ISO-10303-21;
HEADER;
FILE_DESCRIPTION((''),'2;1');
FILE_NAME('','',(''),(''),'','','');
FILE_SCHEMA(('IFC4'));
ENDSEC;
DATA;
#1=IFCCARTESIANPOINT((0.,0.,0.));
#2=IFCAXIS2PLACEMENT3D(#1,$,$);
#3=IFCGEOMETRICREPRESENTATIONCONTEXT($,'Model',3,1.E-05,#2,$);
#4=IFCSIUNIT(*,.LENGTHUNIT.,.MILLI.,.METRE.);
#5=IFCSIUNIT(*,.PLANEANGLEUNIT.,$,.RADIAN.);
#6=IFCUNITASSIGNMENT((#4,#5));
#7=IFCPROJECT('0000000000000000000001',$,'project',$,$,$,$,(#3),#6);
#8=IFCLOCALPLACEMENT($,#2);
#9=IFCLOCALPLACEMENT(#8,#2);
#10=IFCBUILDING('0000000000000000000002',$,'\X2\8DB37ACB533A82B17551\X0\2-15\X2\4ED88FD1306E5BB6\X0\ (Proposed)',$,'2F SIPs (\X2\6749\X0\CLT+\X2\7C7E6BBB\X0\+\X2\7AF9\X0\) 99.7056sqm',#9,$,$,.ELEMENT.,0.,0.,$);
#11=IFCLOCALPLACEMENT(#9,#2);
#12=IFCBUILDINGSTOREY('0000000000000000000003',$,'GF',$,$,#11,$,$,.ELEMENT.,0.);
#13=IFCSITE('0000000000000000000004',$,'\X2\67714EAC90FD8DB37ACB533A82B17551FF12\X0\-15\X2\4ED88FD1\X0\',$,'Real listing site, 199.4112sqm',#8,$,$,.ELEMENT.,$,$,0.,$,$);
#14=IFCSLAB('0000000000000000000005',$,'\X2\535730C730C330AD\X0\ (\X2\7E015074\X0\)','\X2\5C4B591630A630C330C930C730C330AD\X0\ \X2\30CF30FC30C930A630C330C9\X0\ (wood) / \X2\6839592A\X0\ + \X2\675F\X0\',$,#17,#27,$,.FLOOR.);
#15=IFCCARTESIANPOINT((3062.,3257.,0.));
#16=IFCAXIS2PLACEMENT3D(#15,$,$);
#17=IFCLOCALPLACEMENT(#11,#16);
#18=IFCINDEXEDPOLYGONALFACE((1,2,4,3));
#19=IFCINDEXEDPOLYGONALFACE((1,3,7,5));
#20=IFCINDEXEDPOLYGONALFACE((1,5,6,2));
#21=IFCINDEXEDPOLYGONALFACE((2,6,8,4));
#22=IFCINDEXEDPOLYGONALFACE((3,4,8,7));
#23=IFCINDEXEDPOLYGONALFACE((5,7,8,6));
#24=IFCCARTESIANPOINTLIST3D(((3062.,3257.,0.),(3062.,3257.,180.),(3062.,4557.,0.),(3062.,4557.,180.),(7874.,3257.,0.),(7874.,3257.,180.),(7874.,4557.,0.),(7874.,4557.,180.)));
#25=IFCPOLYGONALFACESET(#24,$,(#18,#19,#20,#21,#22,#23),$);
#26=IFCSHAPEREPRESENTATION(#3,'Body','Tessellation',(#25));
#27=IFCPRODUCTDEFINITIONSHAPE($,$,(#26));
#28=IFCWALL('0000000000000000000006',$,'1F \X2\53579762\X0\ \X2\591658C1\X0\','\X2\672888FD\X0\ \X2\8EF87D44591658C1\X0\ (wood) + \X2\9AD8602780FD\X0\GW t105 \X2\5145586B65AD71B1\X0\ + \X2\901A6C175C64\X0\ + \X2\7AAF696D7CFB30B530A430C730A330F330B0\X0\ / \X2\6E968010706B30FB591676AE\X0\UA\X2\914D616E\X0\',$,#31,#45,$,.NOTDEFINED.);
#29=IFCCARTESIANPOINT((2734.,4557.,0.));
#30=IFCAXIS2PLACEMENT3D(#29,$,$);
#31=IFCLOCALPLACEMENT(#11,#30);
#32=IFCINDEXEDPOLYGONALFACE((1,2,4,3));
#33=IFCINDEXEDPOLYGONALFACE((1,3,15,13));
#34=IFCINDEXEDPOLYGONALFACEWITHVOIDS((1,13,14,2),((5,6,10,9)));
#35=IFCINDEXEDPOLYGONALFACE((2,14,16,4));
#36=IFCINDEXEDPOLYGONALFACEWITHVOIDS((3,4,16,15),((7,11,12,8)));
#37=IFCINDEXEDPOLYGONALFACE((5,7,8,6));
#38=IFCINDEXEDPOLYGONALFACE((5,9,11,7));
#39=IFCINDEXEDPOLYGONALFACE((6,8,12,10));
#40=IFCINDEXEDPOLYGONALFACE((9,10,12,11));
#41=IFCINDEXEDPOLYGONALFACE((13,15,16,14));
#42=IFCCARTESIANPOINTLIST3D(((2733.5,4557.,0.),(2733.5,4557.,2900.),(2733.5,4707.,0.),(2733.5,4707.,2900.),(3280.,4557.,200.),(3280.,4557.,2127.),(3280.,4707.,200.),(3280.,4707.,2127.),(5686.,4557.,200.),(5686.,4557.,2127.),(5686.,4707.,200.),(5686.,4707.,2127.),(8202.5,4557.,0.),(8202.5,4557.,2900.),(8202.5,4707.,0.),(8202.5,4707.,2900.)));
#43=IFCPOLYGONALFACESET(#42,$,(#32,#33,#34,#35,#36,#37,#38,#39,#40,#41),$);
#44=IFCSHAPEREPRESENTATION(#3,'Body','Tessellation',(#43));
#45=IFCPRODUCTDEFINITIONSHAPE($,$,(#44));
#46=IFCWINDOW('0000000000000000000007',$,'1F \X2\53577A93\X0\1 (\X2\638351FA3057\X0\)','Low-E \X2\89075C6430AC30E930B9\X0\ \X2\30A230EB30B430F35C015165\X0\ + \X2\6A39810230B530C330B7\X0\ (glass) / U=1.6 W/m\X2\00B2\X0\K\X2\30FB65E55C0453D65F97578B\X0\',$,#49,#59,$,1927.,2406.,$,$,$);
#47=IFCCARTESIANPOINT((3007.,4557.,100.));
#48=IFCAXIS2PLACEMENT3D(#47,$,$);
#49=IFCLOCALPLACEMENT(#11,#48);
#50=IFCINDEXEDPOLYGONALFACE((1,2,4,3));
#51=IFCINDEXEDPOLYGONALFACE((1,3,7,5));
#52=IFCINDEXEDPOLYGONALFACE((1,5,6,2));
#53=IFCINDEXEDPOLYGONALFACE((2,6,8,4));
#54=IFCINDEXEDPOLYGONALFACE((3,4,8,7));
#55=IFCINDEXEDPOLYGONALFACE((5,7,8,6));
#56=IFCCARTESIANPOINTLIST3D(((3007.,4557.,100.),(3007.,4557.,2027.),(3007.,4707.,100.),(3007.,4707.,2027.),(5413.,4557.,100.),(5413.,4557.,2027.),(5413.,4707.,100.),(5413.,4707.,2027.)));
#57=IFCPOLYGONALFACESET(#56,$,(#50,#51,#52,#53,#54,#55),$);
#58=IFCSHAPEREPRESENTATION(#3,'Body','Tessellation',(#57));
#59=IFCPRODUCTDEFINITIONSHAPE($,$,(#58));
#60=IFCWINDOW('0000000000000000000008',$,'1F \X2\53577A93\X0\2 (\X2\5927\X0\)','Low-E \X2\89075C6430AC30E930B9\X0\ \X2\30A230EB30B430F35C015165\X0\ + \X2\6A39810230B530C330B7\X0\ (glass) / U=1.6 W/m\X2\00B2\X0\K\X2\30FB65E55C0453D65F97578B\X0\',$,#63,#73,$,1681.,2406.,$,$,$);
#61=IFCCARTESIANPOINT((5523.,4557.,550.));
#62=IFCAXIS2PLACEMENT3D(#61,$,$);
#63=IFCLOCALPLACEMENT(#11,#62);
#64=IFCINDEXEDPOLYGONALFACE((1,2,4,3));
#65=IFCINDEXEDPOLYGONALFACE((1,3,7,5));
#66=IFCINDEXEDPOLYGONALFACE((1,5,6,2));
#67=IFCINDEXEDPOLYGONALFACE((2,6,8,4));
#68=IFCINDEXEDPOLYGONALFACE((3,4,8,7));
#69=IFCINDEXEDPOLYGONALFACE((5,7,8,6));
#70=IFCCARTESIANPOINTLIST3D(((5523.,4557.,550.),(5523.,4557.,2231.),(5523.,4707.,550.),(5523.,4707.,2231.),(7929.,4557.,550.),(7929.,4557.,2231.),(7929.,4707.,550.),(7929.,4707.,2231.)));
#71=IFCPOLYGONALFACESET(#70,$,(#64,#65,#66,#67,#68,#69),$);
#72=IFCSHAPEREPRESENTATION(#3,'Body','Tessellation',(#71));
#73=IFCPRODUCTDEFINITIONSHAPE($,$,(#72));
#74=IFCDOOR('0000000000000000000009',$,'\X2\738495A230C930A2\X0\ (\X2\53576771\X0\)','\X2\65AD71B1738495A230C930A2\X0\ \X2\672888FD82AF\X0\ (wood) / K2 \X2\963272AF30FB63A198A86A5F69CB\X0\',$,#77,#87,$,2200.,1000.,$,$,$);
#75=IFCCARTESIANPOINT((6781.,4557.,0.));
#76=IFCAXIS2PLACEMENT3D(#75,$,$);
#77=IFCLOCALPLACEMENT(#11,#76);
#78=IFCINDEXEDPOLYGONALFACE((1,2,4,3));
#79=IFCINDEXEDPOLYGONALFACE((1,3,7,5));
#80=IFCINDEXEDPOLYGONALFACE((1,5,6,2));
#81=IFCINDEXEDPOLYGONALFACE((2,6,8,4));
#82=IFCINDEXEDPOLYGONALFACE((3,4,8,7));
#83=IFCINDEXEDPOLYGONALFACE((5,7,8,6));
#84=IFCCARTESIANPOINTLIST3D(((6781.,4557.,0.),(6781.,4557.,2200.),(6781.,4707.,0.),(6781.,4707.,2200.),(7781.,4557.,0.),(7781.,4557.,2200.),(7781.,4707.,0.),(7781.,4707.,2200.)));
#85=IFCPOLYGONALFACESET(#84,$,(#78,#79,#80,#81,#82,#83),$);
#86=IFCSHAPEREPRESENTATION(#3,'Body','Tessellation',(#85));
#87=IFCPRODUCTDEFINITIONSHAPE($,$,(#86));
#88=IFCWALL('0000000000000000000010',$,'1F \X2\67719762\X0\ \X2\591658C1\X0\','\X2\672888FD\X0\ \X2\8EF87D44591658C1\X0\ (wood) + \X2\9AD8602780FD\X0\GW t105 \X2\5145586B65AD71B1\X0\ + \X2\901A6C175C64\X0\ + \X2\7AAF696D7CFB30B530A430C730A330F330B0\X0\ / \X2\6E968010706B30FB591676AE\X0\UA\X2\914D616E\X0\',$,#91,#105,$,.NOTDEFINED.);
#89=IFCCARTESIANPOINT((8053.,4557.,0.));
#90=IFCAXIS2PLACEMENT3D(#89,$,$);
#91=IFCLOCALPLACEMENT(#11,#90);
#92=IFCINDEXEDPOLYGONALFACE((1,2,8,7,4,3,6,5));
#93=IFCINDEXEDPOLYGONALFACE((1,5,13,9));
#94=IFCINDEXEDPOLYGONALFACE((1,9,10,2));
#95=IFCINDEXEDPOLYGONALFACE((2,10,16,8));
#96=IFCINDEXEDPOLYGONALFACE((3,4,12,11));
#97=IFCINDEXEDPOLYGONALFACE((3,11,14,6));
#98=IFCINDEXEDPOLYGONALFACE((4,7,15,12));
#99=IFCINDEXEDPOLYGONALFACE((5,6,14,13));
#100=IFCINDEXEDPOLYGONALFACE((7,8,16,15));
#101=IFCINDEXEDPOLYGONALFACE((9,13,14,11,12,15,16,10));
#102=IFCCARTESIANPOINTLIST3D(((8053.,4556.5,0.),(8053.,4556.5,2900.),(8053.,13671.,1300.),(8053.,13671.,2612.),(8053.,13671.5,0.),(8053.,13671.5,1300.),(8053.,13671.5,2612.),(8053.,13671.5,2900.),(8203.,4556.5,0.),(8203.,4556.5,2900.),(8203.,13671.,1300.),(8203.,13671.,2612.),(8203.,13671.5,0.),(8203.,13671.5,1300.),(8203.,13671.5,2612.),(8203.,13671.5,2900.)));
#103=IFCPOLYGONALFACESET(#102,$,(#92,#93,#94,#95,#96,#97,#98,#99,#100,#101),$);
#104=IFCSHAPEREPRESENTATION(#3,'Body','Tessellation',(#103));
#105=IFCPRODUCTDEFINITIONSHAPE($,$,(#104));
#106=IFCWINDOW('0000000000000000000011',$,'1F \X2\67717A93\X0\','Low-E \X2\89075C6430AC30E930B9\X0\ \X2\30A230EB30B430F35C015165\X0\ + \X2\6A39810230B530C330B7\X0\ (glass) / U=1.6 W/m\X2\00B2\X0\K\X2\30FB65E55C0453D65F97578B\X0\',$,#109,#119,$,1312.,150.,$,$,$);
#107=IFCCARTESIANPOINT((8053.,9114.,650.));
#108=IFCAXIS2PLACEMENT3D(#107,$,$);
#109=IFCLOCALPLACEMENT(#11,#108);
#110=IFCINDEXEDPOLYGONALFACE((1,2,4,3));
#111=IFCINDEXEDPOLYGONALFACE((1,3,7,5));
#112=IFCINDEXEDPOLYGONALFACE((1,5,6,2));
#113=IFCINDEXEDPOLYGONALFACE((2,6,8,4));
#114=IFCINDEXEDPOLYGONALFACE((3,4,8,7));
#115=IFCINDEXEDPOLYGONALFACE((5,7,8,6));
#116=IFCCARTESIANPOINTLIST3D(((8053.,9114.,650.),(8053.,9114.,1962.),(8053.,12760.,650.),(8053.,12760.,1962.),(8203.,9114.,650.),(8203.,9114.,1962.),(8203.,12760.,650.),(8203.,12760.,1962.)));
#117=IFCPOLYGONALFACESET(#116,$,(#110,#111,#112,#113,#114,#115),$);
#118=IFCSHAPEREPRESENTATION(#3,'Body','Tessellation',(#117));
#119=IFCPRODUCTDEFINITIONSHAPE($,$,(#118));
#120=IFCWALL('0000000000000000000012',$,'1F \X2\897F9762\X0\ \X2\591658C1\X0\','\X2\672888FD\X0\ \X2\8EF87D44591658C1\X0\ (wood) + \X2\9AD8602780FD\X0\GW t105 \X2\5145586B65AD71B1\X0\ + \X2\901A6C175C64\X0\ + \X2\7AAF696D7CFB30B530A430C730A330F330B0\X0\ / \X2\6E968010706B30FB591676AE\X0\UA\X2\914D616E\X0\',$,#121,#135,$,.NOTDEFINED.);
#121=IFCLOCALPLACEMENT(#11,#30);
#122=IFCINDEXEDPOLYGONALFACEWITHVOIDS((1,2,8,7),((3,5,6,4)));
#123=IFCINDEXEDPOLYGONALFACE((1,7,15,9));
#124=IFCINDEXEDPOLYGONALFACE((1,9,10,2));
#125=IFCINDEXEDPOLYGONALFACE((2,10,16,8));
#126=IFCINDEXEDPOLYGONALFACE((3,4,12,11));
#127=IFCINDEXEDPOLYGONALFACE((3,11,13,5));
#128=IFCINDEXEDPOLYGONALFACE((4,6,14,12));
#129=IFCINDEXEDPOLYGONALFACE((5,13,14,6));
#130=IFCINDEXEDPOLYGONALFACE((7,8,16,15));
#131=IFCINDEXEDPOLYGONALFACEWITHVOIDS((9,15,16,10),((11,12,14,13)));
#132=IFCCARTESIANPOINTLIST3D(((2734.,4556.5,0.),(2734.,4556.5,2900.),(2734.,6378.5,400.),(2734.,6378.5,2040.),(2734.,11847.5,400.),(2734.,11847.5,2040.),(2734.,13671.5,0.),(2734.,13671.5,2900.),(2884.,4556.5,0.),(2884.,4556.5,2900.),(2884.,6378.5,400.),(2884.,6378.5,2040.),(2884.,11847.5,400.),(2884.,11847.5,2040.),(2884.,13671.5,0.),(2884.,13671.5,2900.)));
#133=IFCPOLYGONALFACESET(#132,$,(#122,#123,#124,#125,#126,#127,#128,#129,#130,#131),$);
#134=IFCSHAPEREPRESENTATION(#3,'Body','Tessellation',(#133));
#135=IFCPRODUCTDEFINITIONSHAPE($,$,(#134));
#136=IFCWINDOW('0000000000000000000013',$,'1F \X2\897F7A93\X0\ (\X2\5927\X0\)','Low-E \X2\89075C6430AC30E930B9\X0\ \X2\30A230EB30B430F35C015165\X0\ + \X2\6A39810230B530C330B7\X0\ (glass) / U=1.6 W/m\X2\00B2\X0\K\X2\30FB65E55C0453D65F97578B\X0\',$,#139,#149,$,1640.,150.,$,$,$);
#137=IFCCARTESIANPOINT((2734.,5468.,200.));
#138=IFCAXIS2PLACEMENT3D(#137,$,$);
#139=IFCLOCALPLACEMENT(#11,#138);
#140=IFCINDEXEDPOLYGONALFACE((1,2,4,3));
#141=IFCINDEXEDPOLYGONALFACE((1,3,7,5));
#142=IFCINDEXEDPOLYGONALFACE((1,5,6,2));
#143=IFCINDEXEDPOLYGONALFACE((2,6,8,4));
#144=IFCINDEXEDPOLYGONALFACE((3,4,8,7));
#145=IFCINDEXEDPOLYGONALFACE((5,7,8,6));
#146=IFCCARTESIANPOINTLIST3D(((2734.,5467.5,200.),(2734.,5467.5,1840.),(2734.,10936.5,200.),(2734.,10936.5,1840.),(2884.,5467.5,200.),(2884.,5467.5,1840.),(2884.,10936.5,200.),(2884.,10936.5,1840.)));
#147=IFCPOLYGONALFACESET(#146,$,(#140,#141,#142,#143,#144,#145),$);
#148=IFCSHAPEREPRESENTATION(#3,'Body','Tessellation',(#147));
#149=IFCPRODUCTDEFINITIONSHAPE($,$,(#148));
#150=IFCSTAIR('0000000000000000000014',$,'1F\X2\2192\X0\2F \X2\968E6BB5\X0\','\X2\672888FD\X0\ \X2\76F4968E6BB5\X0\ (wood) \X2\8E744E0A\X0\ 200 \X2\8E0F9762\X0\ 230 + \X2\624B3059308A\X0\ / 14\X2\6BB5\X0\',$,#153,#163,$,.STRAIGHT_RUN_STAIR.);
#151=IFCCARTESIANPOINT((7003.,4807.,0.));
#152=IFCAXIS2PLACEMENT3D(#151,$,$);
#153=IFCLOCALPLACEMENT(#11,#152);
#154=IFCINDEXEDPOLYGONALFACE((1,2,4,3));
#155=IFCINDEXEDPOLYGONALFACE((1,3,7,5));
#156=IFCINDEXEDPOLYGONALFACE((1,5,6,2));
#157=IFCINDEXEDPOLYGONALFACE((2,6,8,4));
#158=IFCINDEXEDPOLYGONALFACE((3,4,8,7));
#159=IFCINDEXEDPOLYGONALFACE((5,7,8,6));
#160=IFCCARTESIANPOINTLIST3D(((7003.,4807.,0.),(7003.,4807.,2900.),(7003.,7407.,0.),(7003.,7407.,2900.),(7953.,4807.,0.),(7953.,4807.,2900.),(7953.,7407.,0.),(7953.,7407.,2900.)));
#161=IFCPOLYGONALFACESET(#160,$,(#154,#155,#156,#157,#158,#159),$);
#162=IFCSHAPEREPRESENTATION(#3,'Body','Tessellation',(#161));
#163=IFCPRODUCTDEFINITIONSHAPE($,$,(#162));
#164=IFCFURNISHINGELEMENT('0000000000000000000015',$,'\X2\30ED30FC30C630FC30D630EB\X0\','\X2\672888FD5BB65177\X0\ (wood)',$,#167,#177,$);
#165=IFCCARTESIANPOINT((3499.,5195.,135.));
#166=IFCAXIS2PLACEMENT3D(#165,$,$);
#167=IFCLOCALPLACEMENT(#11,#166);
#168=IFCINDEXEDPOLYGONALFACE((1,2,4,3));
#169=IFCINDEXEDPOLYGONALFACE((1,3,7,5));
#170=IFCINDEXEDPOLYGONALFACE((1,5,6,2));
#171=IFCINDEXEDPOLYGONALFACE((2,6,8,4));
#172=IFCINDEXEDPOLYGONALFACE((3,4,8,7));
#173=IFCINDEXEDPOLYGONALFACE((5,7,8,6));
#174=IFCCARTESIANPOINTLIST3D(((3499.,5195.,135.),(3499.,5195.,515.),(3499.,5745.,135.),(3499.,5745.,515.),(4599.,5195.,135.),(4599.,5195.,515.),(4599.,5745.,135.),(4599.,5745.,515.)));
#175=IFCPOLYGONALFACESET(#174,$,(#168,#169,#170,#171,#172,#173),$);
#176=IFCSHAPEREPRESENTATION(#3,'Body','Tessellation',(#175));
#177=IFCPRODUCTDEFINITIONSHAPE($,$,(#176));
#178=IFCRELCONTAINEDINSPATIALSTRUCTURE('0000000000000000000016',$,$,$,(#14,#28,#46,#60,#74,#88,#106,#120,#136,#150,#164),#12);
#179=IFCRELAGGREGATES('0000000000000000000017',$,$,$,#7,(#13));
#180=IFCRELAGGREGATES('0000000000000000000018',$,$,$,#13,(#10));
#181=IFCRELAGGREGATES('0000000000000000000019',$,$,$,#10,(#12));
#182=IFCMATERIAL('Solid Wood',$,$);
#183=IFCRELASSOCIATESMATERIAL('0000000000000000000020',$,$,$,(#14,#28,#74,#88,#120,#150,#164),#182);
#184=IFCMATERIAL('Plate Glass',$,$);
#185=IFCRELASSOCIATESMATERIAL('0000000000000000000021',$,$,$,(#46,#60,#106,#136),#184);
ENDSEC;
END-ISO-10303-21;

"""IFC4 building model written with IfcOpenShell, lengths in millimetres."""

from ifc_helpers import new_model, si_unit, frame, frame_2d, origin, place, context, project, spatial, rectangle, extrude, material, element, fill, save


model = new_model("IFC4")

# Units and contexts
model_context = context("Model", 3, precision=1e-05, world=origin())
ifc_project = project(units=[si_unit("LENGTHUNIT", "METRE", prefix="MILLI"), si_unit("PLANEANGLEUNIT", "RADIAN")], contexts=[model_context])

# Site, building, storey
site_placement = place(None, origin())
site = spatial("IfcSite", under=ifc_project, at=site_placement, Name="東京都足立区花畑２-15付近", ObjectType="Real listing site, 199.4112sqm", CompositionType="ELEMENT", RefElevation=0.0)
building_placement = place(site_placement, origin())
building = spatial("IfcBuilding", under=site, at=building_placement, Name="足立区花畑2-15付近の家 (Proposed)", ObjectType="2F SIPs (杉CLT+籾殻+竹) 99.7056sqm", CompositionType="ELEMENT", ElevationOfRefHeight=0.0, ElevationOfTerrain=0.0)
storey_placement = place(building_placement, origin())
storey = spatial("IfcBuildingStorey", under=building, at=storey_placement, Name="GF", CompositionType="ELEMENT", Elevation=0.0)

# Slab
ifc_material_1 = material(Name="Solid Wood")
slab_1_placement = place(storey_placement, frame((3062.0, 3257.0, 0.0)))
element("IfcSlab", 1, at=slab_1_placement, inside=storey, material=ifc_material_1, Name="南デッキ (縁側)", Description="屋外ウッドデッキ ハードウッド (wood) / 根太 + 束", PredefinedType="FLOOR", context=model_context, shape_type="SweptSolid", body=[
    extrude(rectangle(XDim=4812.0, YDim=1300.0, at=frame_2d((2406.0, 650.0))), frame((3062.0, 3257.0, 0.0)), (0.0, 0.0, 1.0), 180.0),
])

# Wall, openings, windows, door
wall_1_placement = place(storey_placement, frame((2734.0, 4557.0, 0.0)))
wall_1 = element("IfcWall", 2, at=wall_1_placement, inside=storey, material=ifc_material_1, Name="1F 南面 外壁", Description="木製 軸組外壁 (wood) + 高性能GW t105 充填断熱 + 通気層 + 窯業系サイディング / 準耐火・外皮UA配慮", PredefinedType="NOTDEFINED", context=model_context, shape_type="SweptSolid", body=[
    extrude(rectangle(XDim=5469.0, YDim=150.0, at=frame_2d((2734.0, 75.0))), frame((2734.0, 4557.0, 0.0)), (0.0, 0.0, 1.0), 2900.0),
])
opening_1_placement = place(storey_placement, frame((3007.0, 4557.0, 100.0)))
opening_1 = element("IfcOpeningElement", 3, at=opening_1_placement, cuts=wall_1, PredefinedType="NOTDEFINED", context=model_context, shape_type="SweptSolid", body=[
    extrude(rectangle(XDim=2406.0, YDim=150.0, at=frame_2d((1203.0, 75.0))), frame((3007.0, 4557.0, 100.0)), (0.0, 0.0, 1.0), 1927.0),
])
opening_2_placement = place(storey_placement, frame((5523.0, 4557.0, 550.0)))
opening_2 = element("IfcOpeningElement", 4, at=opening_2_placement, cuts=wall_1, PredefinedType="NOTDEFINED", context=model_context, shape_type="SweptSolid", body=[
    extrude(rectangle(XDim=2406.0, YDim=150.0, at=frame_2d((1203.0, 75.0))), frame((5523.0, 4557.0, 550.0)), (0.0, 0.0, 1.0), 1681.0),
])
opening_3_placement = place(storey_placement, frame((6781.0, 4557.0, 0.0)))
opening_3 = element("IfcOpeningElement", 5, at=opening_3_placement, cuts=wall_1, PredefinedType="NOTDEFINED", context=model_context, shape_type="SweptSolid", body=[
    extrude(rectangle(XDim=1000.0, YDim=150.0, at=frame_2d((500.0, 75.0))), frame((6781.0, 4557.0, 0.0)), (0.0, 0.0, 1.0), 2200.0),
])
ifc_material_2 = material(Name="Plate Glass")
window_1_placement = place(storey_placement, frame((3007.0, 4557.0, 100.0)))
window_1 = element("IfcWindow", 6, at=window_1_placement, inside=storey, material=ifc_material_2, Name="1F 南窓1 (掃出し)", Description="Low-E 複層ガラス アルゴン封入 + 樹脂サッシ (glass) / U=1.6 W/m²K・日射取得型", OverallHeight=1927.0, OverallWidth=2406.0, context=model_context, shape_type="SweptSolid", body=[
    extrude(rectangle(XDim=2406.0, YDim=150.0, at=frame_2d((1203.0, 75.0))), frame((3007.0, 4557.0, 100.0)), (0.0, 0.0, 1.0), 1927.0),
])
fill(opening_1, window_1)
window_2_placement = place(storey_placement, frame((5523.0, 4557.0, 550.0)))
window_2 = element("IfcWindow", 7, at=window_2_placement, inside=storey, material=ifc_material_2, Name="1F 南窓2 (大)", Description="Low-E 複層ガラス アルゴン封入 + 樹脂サッシ (glass) / U=1.6 W/m²K・日射取得型", OverallHeight=1681.0, OverallWidth=2406.0, context=model_context, shape_type="SweptSolid", body=[
    extrude(rectangle(XDim=2406.0, YDim=150.0, at=frame_2d((1203.0, 75.0))), frame((5523.0, 4557.0, 550.0)), (0.0, 0.0, 1.0), 1681.0),
])
fill(opening_2, window_2)
door_placement = place(storey_placement, frame((6781.0, 4557.0, 0.0)))
door = element("IfcDoor", 8, at=door_placement, inside=storey, material=ifc_material_1, Name="玄関ドア (南東)", Description="断熱玄関ドア 木製芯 (wood) / K2 防犯・採風機構", OverallHeight=2200.0, OverallWidth=1000.0, context=model_context, shape_type="SweptSolid", body=[
    extrude(rectangle(XDim=1000.0, YDim=150.0, at=frame_2d((500.0, 75.0))), frame((6781.0, 4557.0, 0.0)), (0.0, 0.0, 1.0), 2200.0),
])
fill(opening_3, door)

# Walls, openings, windows
wall_2_placement = place(storey_placement, frame((8053.0, 4557.0, 0.0)))
wall_2 = element("IfcWall", 9, at=wall_2_placement, inside=storey, material=ifc_material_1, Name="1F 東面 外壁", Description="木製 軸組外壁 (wood) + 高性能GW t105 充填断熱 + 通気層 + 窯業系サイディング / 準耐火・外皮UA配慮", PredefinedType="NOTDEFINED", context=model_context, shape_type="SweptSolid", body=[
    extrude(rectangle(XDim=150.0, YDim=9115.0, at=frame_2d((75.0, 4557.0))), frame((8053.0, 4557.0, 0.0)), (0.0, 0.0, 1.0), 2900.0),
])
opening_4_placement = place(storey_placement, frame((8053.0, 9114.0, 650.0)))
opening_4 = element("IfcOpeningElement", 10, at=opening_4_placement, cuts=wall_2, PredefinedType="NOTDEFINED", context=model_context, shape_type="SweptSolid", body=[
    extrude(rectangle(XDim=150.0, YDim=3646.0, at=frame_2d((75.0, 1823.0))), frame((8053.0, 9114.0, 650.0)), (0.0, 0.0, 1.0), 1312.0),
])
window_3_placement = place(storey_placement, frame((8053.0, 9114.0, 650.0)))
window_3 = element("IfcWindow", 11, at=window_3_placement, inside=storey, material=ifc_material_2, Name="1F 東窓", Description="Low-E 複層ガラス アルゴン封入 + 樹脂サッシ (glass) / U=1.6 W/m²K・日射取得型", OverallHeight=1312.0, OverallWidth=150.0, context=model_context, shape_type="SweptSolid", body=[
    extrude(rectangle(XDim=150.0, YDim=3646.0, at=frame_2d((75.0, 1823.0))), frame((8053.0, 9114.0, 650.0)), (0.0, 0.0, 1.0), 1312.0),
])
fill(opening_4, window_3)
wall_3_placement = place(storey_placement, frame((2734.0, 4557.0, 0.0)))
wall_3 = element("IfcWall", 12, at=wall_3_placement, inside=storey, material=ifc_material_1, Name="1F 西面 外壁", Description="木製 軸組外壁 (wood) + 高性能GW t105 充填断熱 + 通気層 + 窯業系サイディング / 準耐火・外皮UA配慮", PredefinedType="NOTDEFINED", context=model_context, shape_type="SweptSolid", body=[
    extrude(rectangle(XDim=150.0, YDim=9115.0, at=frame_2d((75.0, 4557.0))), frame((2734.0, 4557.0, 0.0)), (0.0, 0.0, 1.0), 2900.0),
])
opening_5_placement = place(storey_placement, frame((2734.0, 5468.0, 200.0)))
opening_5 = element("IfcOpeningElement", 13, at=opening_5_placement, cuts=wall_3, PredefinedType="NOTDEFINED", context=model_context, shape_type="SweptSolid", body=[
    extrude(rectangle(XDim=150.0, YDim=5469.0, at=frame_2d((75.0, 2734.0))), frame((2734.0, 5468.0, 200.0)), (0.0, 0.0, 1.0), 1640.0),
])
window_4_placement = place(storey_placement, frame((2734.0, 5468.0, 200.0)))
window_4 = element("IfcWindow", 14, at=window_4_placement, inside=storey, material=ifc_material_2, Name="1F 西窓 (大)", Description="Low-E 複層ガラス アルゴン封入 + 樹脂サッシ (glass) / U=1.6 W/m²K・日射取得型", OverallHeight=1640.0, OverallWidth=150.0, context=model_context, shape_type="SweptSolid", body=[
    extrude(rectangle(XDim=150.0, YDim=5469.0, at=frame_2d((75.0, 2734.0))), frame((2734.0, 5468.0, 200.0)), (0.0, 0.0, 1.0), 1640.0),
])
fill(opening_5, window_4)

# Stair
stair_placement = place(storey_placement, frame((7003.0, 4807.0, 0.0)))
element("IfcStair", 15, at=stair_placement, inside=storey, material=ifc_material_1, Name="1F→2F 階段", Description="木製 直階段 (wood) 蹴上 200 踏面 230 + 手すり / 14段", PredefinedType="STRAIGHT_RUN_STAIR", context=model_context, shape_type="SweptSolid", body=[
    extrude(rectangle(XDim=950.0, YDim=2600.0, at=frame_2d((475.0, 1300.0))), frame((7003.0, 4807.0, 0.0)), (0.0, 0.0, 1.0), 2900.0),
])

# Furnishing element
furnishing_1_placement = place(storey_placement, frame((3499.0, 5195.0, 135.0)))
element("IfcFurnishingElement", 16, at=furnishing_1_placement, inside=storey, material=ifc_material_1, Name="ローテーブル", Description="木製家具 (wood)", context=model_context, shape_type="SweptSolid", body=[
    extrude(rectangle(XDim=1100.0, YDim=550.0, at=frame_2d((550.0, 275.0))), frame((3499.0, 5195.0, 135.0)), (0.0, 0.0, 1.0), 380.0),
])

save(model, "model.ifc")
